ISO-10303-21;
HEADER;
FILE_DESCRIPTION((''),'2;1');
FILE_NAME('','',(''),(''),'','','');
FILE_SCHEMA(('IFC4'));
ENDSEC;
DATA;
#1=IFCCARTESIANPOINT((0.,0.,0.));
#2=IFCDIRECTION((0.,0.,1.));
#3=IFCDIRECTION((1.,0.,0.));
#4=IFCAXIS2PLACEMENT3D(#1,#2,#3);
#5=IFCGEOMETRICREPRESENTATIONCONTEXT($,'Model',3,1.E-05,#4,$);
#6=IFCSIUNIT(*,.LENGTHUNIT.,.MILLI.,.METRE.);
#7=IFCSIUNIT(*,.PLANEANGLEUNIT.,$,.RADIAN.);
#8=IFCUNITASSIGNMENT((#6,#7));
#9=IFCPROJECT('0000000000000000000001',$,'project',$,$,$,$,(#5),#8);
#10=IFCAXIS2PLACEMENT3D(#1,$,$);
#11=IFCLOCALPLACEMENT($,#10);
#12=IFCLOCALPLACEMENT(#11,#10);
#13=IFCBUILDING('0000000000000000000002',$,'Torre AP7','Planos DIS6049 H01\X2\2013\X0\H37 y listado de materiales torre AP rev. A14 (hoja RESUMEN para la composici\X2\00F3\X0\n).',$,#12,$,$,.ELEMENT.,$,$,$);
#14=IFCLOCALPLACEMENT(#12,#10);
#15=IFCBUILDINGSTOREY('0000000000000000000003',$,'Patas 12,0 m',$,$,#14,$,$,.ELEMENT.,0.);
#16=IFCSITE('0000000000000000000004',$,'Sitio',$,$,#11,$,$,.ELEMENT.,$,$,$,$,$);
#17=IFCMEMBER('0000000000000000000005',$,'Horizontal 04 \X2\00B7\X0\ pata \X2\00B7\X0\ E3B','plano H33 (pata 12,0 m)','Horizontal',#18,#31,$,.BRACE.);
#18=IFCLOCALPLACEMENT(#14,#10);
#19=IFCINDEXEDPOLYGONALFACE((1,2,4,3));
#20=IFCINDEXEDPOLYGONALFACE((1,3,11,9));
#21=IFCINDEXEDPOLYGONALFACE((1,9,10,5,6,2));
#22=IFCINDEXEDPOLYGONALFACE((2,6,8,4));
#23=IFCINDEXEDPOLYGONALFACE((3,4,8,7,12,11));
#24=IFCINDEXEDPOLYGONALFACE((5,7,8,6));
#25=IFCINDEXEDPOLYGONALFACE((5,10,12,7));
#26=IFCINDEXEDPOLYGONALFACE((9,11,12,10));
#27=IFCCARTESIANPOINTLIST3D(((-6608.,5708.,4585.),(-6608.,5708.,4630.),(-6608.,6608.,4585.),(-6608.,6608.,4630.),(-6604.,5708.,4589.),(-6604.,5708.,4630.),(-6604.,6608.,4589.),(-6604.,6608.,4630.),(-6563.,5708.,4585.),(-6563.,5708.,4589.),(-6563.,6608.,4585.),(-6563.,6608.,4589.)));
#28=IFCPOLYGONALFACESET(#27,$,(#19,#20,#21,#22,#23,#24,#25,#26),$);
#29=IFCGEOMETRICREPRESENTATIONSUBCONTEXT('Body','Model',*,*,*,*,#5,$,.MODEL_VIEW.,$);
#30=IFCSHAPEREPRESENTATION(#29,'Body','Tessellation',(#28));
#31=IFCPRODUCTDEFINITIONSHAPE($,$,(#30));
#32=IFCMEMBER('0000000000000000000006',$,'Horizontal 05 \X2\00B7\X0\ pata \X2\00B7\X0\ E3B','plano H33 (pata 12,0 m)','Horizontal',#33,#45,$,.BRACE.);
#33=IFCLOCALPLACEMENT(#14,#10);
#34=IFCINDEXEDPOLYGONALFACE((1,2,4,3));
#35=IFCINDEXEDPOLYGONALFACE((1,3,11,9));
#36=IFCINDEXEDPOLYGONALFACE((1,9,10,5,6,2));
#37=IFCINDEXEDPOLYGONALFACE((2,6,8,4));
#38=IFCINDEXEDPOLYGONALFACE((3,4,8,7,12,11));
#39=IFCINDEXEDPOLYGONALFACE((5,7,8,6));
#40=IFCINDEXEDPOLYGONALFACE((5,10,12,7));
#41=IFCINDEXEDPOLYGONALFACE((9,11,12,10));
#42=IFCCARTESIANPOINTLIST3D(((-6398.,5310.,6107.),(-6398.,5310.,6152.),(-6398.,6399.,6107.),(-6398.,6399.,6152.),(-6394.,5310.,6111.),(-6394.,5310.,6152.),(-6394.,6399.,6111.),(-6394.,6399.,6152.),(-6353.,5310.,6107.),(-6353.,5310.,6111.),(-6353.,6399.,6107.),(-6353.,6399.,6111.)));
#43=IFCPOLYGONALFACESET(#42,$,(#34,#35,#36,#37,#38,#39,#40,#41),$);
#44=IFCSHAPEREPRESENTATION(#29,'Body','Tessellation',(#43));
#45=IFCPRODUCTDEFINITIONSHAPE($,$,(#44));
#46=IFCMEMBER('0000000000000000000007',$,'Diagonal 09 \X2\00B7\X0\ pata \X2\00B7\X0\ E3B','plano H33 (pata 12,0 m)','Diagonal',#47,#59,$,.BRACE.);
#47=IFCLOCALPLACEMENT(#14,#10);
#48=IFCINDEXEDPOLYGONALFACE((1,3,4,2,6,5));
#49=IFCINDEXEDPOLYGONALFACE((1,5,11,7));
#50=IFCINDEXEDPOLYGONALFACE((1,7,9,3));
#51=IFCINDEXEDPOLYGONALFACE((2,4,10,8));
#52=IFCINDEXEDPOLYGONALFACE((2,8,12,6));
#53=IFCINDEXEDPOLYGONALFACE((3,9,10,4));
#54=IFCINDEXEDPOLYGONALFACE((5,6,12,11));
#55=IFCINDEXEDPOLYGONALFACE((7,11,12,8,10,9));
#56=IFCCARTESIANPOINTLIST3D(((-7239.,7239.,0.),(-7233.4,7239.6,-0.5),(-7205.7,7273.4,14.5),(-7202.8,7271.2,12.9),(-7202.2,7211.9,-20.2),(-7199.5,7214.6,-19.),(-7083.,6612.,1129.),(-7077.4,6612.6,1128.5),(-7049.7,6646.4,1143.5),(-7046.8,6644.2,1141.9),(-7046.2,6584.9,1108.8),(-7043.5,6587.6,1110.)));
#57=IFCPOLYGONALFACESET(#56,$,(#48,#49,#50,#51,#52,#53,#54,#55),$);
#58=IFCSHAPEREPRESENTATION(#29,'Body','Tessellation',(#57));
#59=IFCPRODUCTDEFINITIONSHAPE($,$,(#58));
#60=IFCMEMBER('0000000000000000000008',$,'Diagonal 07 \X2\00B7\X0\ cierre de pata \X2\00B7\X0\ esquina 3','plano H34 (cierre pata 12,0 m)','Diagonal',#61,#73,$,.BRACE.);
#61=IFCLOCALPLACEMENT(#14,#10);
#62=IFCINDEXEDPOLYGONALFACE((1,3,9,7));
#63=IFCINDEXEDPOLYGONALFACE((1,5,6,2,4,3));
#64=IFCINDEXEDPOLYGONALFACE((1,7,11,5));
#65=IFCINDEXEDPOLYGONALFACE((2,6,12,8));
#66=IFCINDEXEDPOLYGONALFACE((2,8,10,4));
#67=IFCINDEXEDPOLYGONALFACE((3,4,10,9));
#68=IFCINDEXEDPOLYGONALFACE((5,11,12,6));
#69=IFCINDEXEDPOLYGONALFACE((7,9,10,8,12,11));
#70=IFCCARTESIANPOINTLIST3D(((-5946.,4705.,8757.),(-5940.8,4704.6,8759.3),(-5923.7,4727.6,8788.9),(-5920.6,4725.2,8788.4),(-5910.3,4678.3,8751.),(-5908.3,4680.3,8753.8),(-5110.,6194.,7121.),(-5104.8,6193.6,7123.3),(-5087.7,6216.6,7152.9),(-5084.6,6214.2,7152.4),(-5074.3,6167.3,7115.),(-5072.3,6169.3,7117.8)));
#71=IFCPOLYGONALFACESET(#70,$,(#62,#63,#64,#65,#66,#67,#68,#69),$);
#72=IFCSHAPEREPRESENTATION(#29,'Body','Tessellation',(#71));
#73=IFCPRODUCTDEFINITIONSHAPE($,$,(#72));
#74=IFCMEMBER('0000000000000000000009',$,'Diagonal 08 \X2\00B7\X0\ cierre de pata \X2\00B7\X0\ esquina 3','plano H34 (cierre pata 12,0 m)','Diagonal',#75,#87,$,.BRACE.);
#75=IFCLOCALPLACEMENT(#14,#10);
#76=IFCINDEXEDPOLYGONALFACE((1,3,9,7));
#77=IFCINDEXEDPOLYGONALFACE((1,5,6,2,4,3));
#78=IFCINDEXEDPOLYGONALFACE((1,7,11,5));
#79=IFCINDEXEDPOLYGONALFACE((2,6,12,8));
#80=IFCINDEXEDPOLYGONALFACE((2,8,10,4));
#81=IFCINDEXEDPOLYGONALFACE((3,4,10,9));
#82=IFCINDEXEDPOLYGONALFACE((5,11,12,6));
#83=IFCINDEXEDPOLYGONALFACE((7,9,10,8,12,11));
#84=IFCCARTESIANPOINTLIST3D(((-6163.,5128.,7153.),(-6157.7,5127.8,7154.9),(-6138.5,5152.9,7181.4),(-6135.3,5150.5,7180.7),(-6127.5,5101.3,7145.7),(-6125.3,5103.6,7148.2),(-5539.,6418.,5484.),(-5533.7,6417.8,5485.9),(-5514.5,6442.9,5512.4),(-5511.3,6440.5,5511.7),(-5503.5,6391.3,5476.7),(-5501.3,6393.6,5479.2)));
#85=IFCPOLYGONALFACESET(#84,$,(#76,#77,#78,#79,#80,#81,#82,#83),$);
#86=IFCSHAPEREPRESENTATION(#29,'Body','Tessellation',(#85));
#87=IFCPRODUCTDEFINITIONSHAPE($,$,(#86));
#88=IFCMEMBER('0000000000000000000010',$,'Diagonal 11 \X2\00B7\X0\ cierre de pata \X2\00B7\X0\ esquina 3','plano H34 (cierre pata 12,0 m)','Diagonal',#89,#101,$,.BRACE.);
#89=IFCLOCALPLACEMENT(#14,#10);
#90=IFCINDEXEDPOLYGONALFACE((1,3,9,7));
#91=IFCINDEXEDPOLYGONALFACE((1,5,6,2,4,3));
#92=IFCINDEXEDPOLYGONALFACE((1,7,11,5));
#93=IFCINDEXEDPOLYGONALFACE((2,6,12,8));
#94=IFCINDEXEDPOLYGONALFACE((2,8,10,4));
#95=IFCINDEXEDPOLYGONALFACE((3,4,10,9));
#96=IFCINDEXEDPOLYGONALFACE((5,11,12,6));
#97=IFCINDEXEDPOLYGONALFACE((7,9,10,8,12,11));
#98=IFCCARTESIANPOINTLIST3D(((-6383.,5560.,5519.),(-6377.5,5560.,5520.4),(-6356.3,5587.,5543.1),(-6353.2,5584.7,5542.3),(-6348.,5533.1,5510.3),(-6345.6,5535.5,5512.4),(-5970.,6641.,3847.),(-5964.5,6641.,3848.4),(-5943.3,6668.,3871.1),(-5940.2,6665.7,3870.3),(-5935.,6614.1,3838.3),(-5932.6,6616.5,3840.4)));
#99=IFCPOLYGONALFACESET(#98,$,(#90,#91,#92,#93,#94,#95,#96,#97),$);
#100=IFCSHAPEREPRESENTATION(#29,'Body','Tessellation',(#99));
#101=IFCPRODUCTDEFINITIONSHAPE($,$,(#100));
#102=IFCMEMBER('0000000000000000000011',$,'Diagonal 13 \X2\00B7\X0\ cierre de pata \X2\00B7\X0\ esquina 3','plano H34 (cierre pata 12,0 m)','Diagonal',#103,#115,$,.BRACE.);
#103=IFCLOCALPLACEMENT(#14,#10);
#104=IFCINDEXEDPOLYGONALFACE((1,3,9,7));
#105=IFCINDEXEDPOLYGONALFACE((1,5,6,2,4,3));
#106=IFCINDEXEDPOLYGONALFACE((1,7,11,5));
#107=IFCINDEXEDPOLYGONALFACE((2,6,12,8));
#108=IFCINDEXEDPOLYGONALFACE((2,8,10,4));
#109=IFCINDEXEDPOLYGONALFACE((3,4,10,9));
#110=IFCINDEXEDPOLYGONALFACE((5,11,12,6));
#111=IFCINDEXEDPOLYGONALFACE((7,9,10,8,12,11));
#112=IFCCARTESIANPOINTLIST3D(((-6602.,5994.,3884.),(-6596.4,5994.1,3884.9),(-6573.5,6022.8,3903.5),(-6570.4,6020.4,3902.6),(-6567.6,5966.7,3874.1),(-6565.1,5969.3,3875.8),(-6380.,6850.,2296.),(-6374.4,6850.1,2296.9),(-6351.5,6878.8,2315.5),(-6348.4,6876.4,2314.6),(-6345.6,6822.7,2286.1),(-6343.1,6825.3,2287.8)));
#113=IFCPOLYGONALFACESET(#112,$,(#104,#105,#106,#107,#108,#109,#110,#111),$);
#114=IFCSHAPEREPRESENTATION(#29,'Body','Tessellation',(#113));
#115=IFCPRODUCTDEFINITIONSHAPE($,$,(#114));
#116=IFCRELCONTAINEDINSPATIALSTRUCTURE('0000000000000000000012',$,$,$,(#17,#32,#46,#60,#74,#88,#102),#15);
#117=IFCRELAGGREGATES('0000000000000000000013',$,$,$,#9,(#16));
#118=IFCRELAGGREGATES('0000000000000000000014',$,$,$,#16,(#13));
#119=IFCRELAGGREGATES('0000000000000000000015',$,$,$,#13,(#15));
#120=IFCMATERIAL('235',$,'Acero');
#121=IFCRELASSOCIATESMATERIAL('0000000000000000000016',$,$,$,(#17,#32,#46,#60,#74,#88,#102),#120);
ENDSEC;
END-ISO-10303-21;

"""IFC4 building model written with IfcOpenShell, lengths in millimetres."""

from ifc_helpers import new_model, si_unit, frame, frame_2d, origin, origin_with_axes, place, context, subcontext, project, spatial, l_section, extrude, material, element, save


model = new_model("IFC4")

# Units and contexts
model_context = context("Model", 3, precision=1e-05, world=origin_with_axes())
body_context = subcontext(model_context, "Body", "Model", "MODEL_VIEW")
ifc_project = project(units=[si_unit("LENGTHUNIT", "METRE", prefix="MILLI"), si_unit("PLANEANGLEUNIT", "RADIAN")], contexts=[model_context])

# Site, building, storey
site_placement = place(None, origin())
site = spatial("IfcSite", under=ifc_project, at=site_placement, Name="Sitio", CompositionType="ELEMENT")
building_placement = place(site_placement, origin())
building = spatial("IfcBuilding", under=site, at=building_placement, Name="Torre AP7", Description="Planos DIS6049 H01–H37 y listado de materiales torre AP rev. A14 (hoja RESUMEN para la composición).", CompositionType="ELEMENT")
storey_placement = place(building_placement, origin())
storey = spatial("IfcBuildingStorey", under=building, at=storey_placement, Name="Patas 12,0 m", CompositionType="ELEMENT", Elevation=0.0)

# Members
ifc_material_1 = material(Name="235", Category="Acero")
member_1_placement = place(storey_placement, frame((-6608.0, 6608.0, 4585.0), z_axis=(0.0, -1.0, 0.0), x_axis=(1.0, 0.0, 0.0)))
element("IfcMember", 1, at=member_1_placement, inside=storey, material=ifc_material_1, Name="Horizontal 04 · pata · E3B", Description="plano H33 (pata 12,0 m)", ObjectType="Horizontal", PredefinedType="BRACE", context=body_context, shape_type="SweptSolid", body=[
    extrude(l_section(Depth=45.0, Width=45.0, Thickness=4.0, at=frame_2d((22.5, 22.5))), None, (0.0, 0.0, 1.0), 900.0),
])
member_2_placement = place(storey_placement, frame((-6398.0, 6399.0, 6107.0), z_axis=(0.0, -1.0, 0.0), x_axis=(1.0, 0.0, 0.0)))
element("IfcMember", 2, at=member_2_placement, inside=storey, material=ifc_material_1, Name="Horizontal 05 · pata · E3B", Description="plano H33 (pata 12,0 m)", ObjectType="Horizontal", PredefinedType="BRACE", context=body_context, shape_type="SweptSolid", body=[
    extrude(l_section(Depth=45.0, Width=45.0, Thickness=4.0, at=frame_2d((22.5, 22.5))), None, (0.0, 0.0, 1.0), 1089.0),
])
member_3_placement = place(storey_placement, frame((-7239.0, 7239.0, 0.0), z_axis=(0.119925, -0.482007, 0.867921), x_axis=(0.73689, -0.542627, -0.403173)))
element("IfcMember", 3, at=member_3_placement, inside=storey, material=ifc_material_1, Name="Diagonal 09 · pata · E3B", Description="plano H33 (pata 12,0 m)", ObjectType="Diagonal", PredefinedType="BRACE", context=body_context, shape_type="SweptSolid", body=[
    extrude(l_section(Depth=50.0, Width=50.0, Thickness=4.0, at=frame_2d((25.0, 25.0))), None, (0.0, 0.0, 1.0), 1300.8),
])
member_4_placement = place(storey_placement, frame((-5110.0, 6194.0, 7121.0), z_axis=(-0.353511, -0.629638, 0.691799), x_axis=(0.793914, -0.593062, -0.134082)))
element("IfcMember", 4, at=member_4_placement, inside=storey, material=ifc_material_1, Name="Diagonal 07 · cierre de pata · esquina 3", Description="plano H34 (cierre pata 12,0 m)", ObjectType="Diagonal", PredefinedType="BRACE", context=body_context, shape_type="SweptSolid", body=[
    extrude(l_section(Depth=45.0, Width=45.0, Thickness=4.0, at=frame_2d((22.5, 22.5))), None, (0.0, 0.0, 1.0), 2364.8),
])
member_5_placement = place(storey_placement, frame((-5539.0, 6418.0, 5484.0), z_axis=(-0.283665, -0.586422, 0.758712), x_axis=(0.788975, -0.592431, -0.162922)))
element("IfcMember", 5, at=member_5_placement, inside=storey, material=ifc_material_1, Name="Diagonal 08 · cierre de pata · esquina 3", Description="plano H34 (cierre pata 12,0 m)", ObjectType="Diagonal", PredefinedType="BRACE", context=body_context, shape_type="SweptSolid", body=[
    extrude(l_section(Depth=45.0, Width=45.0, Thickness=4.0, at=frame_2d((22.5, 22.5))), None, (0.0, 0.0, 1.0), 2199.8),
])
member_6_placement = place(storey_placement, frame((-5970.0, 6641.0, 3847.0), z_axis=(-0.203108, -0.531622, 0.822268), x_axis=(0.778704, -0.596805, -0.193506)))
element("IfcMember", 6, at=member_6_placement, inside=storey, material=ifc_material_1, Name="Diagonal 11 · cierre de pata · esquina 3", Description="plano H34 (cierre pata 12,0 m)", ObjectType="Diagonal", PredefinedType="BRACE", context=body_context, shape_type="SweptSolid", body=[
    extrude(l_section(Depth=45.0, Width=45.0, Thickness=4.0, at=frame_2d((22.5, 22.5))), None, (0.0, 0.0, 1.0), 2033.4),
])
member_7_placement = place(storey_placement, frame((-6380.0, 6850.0, 2296.0), z_axis=(-0.122137, -0.470944, 0.873667), x_axis=(0.76389, -0.606616, -0.220201)))
element("IfcMember", 7, at=member_7_placement, inside=storey, material=ifc_material_1, Name="Diagonal 13 · cierre de pata · esquina 3", Description="plano H34 (cierre pata 12,0 m)", ObjectType="Diagonal", PredefinedType="BRACE", context=body_context, shape_type="SweptSolid", body=[
    extrude(l_section(Depth=45.0, Width=45.0, Thickness=4.0, at=frame_2d((22.5, 22.5))), None, (0.0, 0.0, 1.0), 1817.6),
])

save(model, "model.ifc")
